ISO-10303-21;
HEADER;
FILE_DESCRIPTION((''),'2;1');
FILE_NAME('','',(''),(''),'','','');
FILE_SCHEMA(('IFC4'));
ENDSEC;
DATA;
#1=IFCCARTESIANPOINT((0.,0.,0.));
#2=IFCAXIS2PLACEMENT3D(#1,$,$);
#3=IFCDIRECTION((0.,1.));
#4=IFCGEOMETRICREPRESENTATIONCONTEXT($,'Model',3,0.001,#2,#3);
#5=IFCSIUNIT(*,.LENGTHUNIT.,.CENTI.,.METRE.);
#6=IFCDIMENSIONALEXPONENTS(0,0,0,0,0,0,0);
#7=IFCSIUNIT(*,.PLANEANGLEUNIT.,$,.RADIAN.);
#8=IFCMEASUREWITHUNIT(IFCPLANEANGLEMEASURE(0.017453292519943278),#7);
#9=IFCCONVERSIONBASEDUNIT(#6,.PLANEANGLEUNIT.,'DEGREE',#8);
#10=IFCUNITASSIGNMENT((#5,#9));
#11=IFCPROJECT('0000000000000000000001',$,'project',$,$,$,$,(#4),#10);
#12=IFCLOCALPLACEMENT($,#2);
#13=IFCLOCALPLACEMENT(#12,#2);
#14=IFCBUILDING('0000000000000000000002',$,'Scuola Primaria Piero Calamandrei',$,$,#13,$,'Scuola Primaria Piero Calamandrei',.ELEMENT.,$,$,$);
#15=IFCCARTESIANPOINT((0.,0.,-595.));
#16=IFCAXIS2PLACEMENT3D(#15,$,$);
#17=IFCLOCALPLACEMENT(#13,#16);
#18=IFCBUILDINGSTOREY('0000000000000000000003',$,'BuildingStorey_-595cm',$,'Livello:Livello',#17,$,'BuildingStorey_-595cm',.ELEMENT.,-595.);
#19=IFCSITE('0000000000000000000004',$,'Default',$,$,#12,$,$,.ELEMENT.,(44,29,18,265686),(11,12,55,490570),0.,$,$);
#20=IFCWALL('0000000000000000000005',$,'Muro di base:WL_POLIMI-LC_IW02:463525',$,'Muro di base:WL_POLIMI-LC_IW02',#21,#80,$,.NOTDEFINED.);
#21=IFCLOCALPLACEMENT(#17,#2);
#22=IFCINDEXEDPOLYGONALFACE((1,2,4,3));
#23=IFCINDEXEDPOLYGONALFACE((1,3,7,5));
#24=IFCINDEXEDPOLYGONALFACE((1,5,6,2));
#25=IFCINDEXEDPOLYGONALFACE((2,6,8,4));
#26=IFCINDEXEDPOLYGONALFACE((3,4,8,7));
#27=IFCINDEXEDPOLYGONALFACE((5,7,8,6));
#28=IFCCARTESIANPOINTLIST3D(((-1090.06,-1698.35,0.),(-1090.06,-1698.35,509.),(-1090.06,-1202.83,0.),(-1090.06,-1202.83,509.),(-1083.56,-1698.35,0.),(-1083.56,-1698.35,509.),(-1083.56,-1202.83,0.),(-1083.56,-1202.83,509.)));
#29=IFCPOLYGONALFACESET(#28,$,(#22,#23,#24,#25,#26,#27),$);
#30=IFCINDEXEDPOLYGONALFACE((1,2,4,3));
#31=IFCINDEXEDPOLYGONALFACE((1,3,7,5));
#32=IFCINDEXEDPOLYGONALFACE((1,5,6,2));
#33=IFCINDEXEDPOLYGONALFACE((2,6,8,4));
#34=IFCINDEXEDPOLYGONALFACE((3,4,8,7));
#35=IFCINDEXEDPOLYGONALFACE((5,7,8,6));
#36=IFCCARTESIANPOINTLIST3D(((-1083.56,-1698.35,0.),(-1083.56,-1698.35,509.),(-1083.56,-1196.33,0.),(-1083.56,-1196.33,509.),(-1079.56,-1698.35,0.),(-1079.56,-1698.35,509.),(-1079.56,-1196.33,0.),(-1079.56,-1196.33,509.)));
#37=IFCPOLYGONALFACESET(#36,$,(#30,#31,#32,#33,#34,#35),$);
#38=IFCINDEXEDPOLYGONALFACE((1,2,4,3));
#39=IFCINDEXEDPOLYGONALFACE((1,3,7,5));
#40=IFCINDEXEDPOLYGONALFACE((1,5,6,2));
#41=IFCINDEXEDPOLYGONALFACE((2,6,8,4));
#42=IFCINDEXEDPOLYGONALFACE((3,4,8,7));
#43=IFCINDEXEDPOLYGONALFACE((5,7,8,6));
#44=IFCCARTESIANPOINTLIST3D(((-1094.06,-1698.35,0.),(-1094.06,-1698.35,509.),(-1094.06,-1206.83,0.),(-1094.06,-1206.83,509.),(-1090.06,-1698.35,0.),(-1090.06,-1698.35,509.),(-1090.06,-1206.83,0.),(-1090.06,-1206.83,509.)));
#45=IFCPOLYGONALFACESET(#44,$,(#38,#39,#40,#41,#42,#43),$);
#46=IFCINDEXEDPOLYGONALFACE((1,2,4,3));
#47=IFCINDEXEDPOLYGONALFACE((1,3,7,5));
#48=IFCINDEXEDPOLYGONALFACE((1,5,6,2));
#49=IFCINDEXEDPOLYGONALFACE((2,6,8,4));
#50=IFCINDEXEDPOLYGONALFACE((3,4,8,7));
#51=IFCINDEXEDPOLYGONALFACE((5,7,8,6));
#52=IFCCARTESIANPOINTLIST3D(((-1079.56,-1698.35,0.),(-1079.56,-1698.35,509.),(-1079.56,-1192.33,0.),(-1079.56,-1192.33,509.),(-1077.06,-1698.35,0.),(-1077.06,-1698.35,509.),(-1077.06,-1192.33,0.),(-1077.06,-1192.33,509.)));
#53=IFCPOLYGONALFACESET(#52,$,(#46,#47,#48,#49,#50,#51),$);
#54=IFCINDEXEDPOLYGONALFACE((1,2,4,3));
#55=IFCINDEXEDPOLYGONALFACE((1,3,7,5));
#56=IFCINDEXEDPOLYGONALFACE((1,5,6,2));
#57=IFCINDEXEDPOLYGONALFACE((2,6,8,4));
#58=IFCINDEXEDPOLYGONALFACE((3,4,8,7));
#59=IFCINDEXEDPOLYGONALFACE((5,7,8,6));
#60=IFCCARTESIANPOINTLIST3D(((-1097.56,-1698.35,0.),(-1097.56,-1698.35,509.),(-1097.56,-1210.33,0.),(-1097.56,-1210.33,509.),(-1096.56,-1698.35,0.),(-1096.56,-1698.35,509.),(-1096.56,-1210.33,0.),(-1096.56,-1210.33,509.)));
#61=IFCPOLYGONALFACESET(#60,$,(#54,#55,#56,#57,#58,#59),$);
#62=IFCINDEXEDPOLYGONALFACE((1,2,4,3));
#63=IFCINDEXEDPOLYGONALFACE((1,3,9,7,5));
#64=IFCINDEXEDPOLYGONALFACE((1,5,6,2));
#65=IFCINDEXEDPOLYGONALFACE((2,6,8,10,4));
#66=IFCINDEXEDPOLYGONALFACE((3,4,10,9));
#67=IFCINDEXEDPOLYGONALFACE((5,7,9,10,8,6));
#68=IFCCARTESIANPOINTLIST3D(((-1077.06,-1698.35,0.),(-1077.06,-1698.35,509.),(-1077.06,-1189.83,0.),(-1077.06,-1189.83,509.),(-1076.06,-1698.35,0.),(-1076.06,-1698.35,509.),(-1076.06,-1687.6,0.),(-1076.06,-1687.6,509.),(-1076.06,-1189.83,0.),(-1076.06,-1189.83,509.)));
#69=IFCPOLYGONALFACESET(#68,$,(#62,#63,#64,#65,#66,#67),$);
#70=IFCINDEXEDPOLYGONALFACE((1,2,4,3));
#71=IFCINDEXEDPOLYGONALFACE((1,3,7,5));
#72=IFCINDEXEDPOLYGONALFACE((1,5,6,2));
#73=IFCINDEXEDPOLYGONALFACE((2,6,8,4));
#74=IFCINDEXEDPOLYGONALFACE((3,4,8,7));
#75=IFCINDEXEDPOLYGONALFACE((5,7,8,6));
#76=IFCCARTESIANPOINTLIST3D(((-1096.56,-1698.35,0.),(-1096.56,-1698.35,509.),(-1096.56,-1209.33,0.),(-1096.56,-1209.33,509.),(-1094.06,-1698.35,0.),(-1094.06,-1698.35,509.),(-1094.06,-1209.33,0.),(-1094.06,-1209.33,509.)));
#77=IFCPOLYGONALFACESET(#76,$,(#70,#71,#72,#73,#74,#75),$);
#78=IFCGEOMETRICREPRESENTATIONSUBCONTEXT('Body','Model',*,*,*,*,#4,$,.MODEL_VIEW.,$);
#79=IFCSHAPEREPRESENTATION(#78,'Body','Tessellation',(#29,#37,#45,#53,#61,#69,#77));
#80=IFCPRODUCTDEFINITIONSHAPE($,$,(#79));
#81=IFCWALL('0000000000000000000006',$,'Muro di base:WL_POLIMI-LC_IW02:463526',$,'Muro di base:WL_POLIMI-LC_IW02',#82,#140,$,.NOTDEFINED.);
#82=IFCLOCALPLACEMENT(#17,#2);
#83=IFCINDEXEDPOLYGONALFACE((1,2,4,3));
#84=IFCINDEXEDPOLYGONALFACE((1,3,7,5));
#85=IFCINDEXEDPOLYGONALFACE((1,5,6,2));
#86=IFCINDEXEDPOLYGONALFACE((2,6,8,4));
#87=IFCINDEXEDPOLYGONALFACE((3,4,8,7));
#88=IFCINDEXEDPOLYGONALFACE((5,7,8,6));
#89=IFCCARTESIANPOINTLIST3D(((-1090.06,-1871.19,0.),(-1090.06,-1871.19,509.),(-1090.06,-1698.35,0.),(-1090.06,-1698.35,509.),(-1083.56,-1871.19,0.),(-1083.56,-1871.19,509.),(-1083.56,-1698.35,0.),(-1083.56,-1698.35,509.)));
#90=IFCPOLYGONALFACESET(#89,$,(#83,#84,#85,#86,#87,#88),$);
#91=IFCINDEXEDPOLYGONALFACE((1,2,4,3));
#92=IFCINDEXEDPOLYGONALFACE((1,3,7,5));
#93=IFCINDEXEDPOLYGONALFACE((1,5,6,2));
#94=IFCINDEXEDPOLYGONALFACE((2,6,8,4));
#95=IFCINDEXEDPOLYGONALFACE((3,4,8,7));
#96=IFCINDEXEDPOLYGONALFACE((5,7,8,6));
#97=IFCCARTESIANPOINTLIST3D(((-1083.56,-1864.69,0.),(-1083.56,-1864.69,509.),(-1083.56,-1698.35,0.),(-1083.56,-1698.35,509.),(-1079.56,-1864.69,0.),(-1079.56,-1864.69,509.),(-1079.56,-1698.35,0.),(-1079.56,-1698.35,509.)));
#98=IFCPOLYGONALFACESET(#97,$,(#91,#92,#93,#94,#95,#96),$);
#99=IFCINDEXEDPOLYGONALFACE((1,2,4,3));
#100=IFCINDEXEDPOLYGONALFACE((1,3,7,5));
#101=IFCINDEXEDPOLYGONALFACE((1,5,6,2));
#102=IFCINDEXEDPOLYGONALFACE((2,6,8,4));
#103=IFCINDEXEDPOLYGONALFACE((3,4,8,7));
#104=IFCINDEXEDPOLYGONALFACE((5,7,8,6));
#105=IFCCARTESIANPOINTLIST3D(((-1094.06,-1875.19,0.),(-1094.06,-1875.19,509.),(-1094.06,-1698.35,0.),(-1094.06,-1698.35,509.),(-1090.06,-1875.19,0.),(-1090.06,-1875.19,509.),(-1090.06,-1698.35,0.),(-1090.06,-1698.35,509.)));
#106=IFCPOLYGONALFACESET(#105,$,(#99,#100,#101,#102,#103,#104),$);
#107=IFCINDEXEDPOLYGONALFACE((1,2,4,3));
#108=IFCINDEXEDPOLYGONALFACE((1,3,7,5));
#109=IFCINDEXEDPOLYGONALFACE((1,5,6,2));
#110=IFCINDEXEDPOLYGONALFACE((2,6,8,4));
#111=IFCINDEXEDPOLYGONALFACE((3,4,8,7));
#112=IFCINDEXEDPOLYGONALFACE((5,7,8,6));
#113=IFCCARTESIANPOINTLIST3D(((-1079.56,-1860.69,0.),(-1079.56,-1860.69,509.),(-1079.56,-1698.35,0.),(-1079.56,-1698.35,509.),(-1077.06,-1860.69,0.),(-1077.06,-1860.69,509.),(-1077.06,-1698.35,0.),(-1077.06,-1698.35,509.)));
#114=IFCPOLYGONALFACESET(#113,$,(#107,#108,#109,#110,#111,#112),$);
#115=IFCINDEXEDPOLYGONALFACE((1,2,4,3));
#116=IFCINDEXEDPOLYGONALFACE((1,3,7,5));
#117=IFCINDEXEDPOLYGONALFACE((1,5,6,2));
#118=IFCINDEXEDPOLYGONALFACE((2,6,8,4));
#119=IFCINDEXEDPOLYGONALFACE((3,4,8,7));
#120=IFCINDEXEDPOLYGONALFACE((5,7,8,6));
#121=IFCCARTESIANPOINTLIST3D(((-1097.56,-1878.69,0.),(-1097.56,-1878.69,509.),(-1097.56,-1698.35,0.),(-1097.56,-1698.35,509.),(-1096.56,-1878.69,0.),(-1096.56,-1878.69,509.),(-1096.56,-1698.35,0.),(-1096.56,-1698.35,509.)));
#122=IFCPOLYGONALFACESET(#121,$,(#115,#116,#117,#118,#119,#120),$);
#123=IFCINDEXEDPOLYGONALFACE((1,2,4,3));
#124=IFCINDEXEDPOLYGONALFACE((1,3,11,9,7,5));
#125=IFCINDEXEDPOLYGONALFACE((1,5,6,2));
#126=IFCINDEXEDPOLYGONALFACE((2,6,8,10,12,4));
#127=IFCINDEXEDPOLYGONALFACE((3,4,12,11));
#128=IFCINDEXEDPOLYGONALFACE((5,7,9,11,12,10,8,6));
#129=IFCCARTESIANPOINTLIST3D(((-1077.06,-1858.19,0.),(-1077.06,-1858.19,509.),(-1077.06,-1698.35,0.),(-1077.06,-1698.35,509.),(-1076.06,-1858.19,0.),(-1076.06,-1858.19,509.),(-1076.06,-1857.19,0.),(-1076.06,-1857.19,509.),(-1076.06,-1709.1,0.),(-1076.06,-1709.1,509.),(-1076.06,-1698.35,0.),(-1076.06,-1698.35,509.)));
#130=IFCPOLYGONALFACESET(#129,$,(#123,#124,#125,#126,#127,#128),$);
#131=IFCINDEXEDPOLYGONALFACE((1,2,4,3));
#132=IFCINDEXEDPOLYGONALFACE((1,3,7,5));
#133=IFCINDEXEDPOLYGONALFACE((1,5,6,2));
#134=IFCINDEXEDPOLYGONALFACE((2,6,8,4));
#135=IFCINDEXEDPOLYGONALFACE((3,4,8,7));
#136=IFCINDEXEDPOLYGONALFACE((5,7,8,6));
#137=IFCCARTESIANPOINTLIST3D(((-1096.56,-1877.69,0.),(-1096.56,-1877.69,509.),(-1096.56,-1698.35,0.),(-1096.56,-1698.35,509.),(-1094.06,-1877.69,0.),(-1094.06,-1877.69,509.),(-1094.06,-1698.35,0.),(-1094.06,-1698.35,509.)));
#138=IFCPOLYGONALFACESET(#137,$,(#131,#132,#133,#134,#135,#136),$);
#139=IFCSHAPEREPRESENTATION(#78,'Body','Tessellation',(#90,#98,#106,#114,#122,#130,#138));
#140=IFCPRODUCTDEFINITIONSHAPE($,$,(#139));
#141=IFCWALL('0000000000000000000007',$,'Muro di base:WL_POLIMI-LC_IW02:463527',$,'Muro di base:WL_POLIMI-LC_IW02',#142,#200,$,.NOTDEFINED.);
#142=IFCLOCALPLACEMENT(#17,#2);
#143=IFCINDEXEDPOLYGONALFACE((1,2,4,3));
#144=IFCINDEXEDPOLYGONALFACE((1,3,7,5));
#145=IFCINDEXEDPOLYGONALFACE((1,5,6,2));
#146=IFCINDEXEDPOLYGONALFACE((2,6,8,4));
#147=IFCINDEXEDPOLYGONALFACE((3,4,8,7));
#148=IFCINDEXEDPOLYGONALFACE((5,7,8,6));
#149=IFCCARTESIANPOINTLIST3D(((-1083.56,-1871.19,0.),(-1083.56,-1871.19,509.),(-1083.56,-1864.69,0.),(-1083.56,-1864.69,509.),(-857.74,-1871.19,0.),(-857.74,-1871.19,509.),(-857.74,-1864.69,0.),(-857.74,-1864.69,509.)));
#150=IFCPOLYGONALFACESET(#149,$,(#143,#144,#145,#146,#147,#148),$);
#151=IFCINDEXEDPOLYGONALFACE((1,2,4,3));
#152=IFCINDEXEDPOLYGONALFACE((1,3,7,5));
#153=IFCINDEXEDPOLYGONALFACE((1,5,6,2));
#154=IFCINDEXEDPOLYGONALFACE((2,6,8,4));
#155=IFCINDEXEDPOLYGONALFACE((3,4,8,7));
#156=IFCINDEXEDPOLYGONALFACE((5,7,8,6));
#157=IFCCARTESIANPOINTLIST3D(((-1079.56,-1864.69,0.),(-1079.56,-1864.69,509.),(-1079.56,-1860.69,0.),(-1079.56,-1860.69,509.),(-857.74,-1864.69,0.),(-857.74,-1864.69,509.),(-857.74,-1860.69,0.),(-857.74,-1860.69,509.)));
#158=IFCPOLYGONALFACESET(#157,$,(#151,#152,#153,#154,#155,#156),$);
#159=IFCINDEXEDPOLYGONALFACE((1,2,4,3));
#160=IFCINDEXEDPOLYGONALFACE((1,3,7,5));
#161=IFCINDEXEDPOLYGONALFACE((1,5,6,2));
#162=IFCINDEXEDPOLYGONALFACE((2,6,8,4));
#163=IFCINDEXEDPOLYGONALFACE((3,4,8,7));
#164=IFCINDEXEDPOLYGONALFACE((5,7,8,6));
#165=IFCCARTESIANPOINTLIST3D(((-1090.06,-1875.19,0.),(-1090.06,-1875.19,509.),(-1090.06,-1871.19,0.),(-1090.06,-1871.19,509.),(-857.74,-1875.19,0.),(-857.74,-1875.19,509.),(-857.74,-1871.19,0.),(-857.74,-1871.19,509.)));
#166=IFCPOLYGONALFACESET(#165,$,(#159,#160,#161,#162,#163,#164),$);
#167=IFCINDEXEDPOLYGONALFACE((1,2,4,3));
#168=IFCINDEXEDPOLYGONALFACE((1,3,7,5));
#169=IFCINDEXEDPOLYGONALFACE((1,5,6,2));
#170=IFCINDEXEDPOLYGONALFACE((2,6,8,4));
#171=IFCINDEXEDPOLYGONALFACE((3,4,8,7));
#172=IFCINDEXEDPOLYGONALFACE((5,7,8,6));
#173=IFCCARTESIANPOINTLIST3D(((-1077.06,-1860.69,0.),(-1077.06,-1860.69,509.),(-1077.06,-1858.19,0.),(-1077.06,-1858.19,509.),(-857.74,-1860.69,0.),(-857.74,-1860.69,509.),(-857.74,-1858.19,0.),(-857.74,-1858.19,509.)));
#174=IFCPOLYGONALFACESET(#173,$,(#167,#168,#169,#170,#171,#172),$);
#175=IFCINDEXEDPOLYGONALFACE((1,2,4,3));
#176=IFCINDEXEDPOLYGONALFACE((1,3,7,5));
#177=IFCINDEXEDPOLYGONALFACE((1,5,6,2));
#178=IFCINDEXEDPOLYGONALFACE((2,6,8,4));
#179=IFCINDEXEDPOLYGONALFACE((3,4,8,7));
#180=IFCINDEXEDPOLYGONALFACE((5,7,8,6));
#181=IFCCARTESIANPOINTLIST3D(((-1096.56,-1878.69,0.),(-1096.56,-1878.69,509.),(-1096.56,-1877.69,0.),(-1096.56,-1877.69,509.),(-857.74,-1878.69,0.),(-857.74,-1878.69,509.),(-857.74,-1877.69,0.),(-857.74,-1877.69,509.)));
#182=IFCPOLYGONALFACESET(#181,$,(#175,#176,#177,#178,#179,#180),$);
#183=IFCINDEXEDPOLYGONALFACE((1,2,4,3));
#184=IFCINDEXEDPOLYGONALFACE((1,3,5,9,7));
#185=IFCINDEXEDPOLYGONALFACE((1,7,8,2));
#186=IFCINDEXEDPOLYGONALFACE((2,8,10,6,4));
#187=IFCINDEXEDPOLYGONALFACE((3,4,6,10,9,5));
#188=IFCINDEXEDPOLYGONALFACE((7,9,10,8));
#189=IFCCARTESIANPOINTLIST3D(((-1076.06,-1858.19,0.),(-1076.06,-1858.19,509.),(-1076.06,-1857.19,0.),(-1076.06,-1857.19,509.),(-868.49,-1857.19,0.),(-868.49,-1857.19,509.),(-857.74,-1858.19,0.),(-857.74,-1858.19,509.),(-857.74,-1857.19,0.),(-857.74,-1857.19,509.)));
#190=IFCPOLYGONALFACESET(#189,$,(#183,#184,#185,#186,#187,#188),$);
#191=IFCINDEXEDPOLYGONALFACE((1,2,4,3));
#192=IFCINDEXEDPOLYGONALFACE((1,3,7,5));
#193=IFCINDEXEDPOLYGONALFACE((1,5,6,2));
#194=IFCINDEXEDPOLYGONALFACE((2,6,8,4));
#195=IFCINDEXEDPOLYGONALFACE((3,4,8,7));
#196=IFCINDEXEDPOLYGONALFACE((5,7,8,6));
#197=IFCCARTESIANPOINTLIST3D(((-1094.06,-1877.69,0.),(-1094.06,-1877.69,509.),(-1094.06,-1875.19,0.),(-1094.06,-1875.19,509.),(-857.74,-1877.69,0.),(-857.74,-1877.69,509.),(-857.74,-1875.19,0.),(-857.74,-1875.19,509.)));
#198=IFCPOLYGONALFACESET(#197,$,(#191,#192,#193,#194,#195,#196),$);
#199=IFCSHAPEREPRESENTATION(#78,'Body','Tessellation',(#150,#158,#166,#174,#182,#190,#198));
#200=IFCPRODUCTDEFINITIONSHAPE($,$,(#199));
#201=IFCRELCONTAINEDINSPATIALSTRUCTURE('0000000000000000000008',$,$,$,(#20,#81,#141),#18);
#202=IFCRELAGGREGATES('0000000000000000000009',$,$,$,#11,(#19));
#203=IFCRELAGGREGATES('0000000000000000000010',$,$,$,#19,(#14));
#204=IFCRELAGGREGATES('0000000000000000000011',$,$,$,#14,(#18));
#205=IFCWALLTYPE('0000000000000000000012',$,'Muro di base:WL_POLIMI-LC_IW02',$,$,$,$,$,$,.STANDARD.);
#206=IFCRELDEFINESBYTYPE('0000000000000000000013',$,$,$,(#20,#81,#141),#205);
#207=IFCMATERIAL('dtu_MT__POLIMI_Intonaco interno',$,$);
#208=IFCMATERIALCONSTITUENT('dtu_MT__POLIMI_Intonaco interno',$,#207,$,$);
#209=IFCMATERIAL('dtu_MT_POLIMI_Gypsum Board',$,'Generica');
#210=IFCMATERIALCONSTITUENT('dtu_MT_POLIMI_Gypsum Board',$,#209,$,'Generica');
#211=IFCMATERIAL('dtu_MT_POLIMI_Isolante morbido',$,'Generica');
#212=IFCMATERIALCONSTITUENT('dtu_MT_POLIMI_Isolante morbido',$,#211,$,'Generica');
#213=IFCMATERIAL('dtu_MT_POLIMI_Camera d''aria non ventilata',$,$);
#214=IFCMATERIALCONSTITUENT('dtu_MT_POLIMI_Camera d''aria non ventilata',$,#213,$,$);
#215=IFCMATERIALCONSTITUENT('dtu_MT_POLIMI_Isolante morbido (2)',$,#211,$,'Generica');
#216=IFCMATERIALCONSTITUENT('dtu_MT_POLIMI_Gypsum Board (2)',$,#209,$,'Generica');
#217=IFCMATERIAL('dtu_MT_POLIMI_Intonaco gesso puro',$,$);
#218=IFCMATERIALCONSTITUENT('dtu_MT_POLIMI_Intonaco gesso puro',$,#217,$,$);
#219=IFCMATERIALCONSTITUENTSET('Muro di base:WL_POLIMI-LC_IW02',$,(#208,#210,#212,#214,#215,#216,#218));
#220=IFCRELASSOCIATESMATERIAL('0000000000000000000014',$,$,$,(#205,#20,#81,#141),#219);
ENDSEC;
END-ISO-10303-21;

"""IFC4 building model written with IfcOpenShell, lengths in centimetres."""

from ifc_helpers import new_model, entity, si_unit, converted_unit, direction, frame, origin, place, context, subcontext, project, spatial, indexed_curve, outline, extrude, material, constituent, constituent_set, type_object, element, save


model = new_model("IFC4")

# Units and contexts
model_context = context("Model", 3, precision=0.001, world=origin(), true_north=direction((0.0, 1.0)))
body_context = subcontext(model_context, "Body", "Model", "MODEL_VIEW")
ifc_project = project(units=[si_unit("LENGTHUNIT", "METRE", prefix="CENTI"), converted_unit("PLANEANGLEUNIT", "DEGREE", entity("IfcPlaneAngleMeasure", 0.017453292519943278), si_unit("PLANEANGLEUNIT", "RADIAN"), dimensions=[0, 0, 0, 0, 0, 0, 0])], contexts=[model_context])

# Site, building, storey
site_placement = place(None, origin())
site = spatial("IfcSite", under=ifc_project, at=site_placement, Name="Default", CompositionType="ELEMENT", RefLatitude=(44, 29, 18, 265686), RefLongitude=(11, 12, 55, 490570), RefElevation=0.0)
building_placement = place(site_placement, origin())
building = spatial("IfcBuilding", under=site, at=building_placement, Name="Scuola Primaria Piero Calamandrei", LongName="Scuola Primaria Piero Calamandrei", CompositionType="ELEMENT")
storey_placement = place(building_placement, frame((0.0, 0.0, -595.0)))
storey = spatial("IfcBuildingStorey", under=building, at=storey_placement, Name="BuildingStorey_-595cm", ObjectType="Livello:Livello", LongName="BuildingStorey_-595cm", CompositionType="ELEMENT", Elevation=-595.0)

# Shared definitions
ifc_material_1 = material(Name="dtu_MT__POLIMI_Intonaco interno")

# Walls
ifc_constituent_1 = constituent(ifc_material_1, Name="dtu_MT__POLIMI_Intonaco interno")
ifc_material_2 = material(Name="dtu_MT_POLIMI_Gypsum Board", Category="Generica")
ifc_constituent_2 = constituent(ifc_material_2, Name="dtu_MT_POLIMI_Gypsum Board", Category="Generica")
ifc_material_3 = material(Name="dtu_MT_POLIMI_Isolante morbido", Category="Generica")
ifc_constituent_3 = constituent(ifc_material_3, Name="dtu_MT_POLIMI_Isolante morbido", Category="Generica")
ifc_material_4 = material(Name="dtu_MT_POLIMI_Camera d'aria non ventilata")
ifc_constituent_4 = constituent(ifc_material_4, Name="dtu_MT_POLIMI_Camera d'aria non ventilata")
ifc_constituent_5 = constituent(ifc_material_3, Name="dtu_MT_POLIMI_Isolante morbido (2)", Category="Generica")
ifc_constituent_6 = constituent(ifc_material_2, Name="dtu_MT_POLIMI_Gypsum Board (2)", Category="Generica")
ifc_material_5 = material(Name="dtu_MT_POLIMI_Intonaco gesso puro")
ifc_constituent_7 = constituent(ifc_material_5, Name="dtu_MT_POLIMI_Intonaco gesso puro")
ifc_constituent_set_1 = constituent_set(constituents=[ifc_constituent_1, ifc_constituent_2, ifc_constituent_3, ifc_constituent_4, ifc_constituent_5, ifc_constituent_6, ifc_constituent_7], Name="Muro di base:WL_POLIMI-LC_IW02")
wall_type_1 = type_object("IfcWallType", Name="Muro di base:WL_POLIMI-LC_IW02", PredefinedType="STANDARD", material=ifc_constituent_set_1)
wall_1_placement = place(storey_placement, frame((-1086.81, -1210.33, 0.0), z_axis=(0.0, 0.0, 1.0), x_axis=(0.0, -1.0, 0.0)))
element("IfcWall", 1, at=wall_1_placement, inside=storey, type_object=wall_type_1, material=ifc_constituent_set_1, Name="Muro di base:WL_POLIMI-LC_IW02:463525", ObjectType="Muro di base:WL_POLIMI-LC_IW02", PredefinedType="NOTDEFINED", context=body_context, shape_type="SweptSolid", body=[
    extrude(outline(indexed_curve([(-247.76, -3.25), (247.76, -3.25), (247.76, 3.25), (-247.76, 3.25), (-247.76, -3.25)], self_intersect=False)), frame((240.26, 0.0, 0.0)), (0.0, 0.0, 1.0), 509.0),
    extrude(outline(indexed_curve([(-251.01, -2.0), (251.01, -2.0), (251.01, 2.0), (-251.01, 2.0), (-251.01, -2.0)], self_intersect=False)), frame((237.01, 5.25, 0.0)), (0.0, 0.0, 1.0), 509.0),
    extrude(outline(indexed_curve([(-245.76, -2.0), (245.76, -2.0), (245.76, 2.0), (-245.76, 2.0), (-245.76, -2.0)], self_intersect=False)), frame((242.26, -5.25, 0.0)), (0.0, 0.0, 1.0), 509.0),
    extrude(outline(indexed_curve([(-253.01, -1.25), (253.01, -1.25), (253.01, 1.25), (-253.01, 1.25), (-253.01, -1.25)], self_intersect=False)), frame((235.01, 8.5, 0.0)), (0.0, 0.0, 1.0), 509.0),
    extrude(outline(indexed_curve([(-0.5, -244.01), (0.5, -244.01), (0.5, 244.01), (-0.5, 244.01), (-0.5, -244.01)], self_intersect=False)), frame((244.01, -10.25, 0.0), z_axis=(0.0, 0.0, 1.0), x_axis=(0.0, 1.0, 0.0)), (0.0, 0.0, 1.0), 509.0),
    extrude(outline(indexed_curve([(-194.81, -0.4), (302.97, -0.4), (302.97, 0.6), (-205.56, 0.6), (-205.56, -0.4), (-194.81, -0.4)], self_intersect=False)), frame((282.47, 10.35, 0.0), z_axis=(0.0, 0.0, 1.0), x_axis=(-1.0, 0.0, 0.0)), (0.0, 0.0, 1.0), 509.0),
    extrude(outline(indexed_curve([(-244.51, -1.25), (244.51, -1.25), (244.51, 1.25), (-244.51, 1.25), (-244.51, -1.25)], self_intersect=False)), frame((243.51, -8.5, 0.0)), (0.0, 0.0, 1.0), 509.0),
])
wall_2_placement = place(storey_placement, frame((-1086.81, -1698.35, 0.0), z_axis=(0.0, 0.0, 1.0), x_axis=(0.0, -1.0, 0.0)))
element("IfcWall", 2, at=wall_2_placement, inside=storey, type_object=wall_type_1, material=ifc_constituent_set_1, Name="Muro di base:WL_POLIMI-LC_IW02:463526", ObjectType="Muro di base:WL_POLIMI-LC_IW02", PredefinedType="NOTDEFINED", context=body_context, shape_type="SweptSolid", body=[
    extrude(outline(indexed_curve([(-86.42, -3.25), (86.42, -3.25), (86.42, 3.25), (-86.42, 3.25), (-86.42, -3.25)], self_intersect=False)), frame((86.42, 0.0, 0.0)), (0.0, 0.0, 1.0), 509.0),
    extrude(outline(indexed_curve([(-83.17, -2.0), (83.17, -2.0), (83.17, 2.0), (-83.17, 2.0), (-83.17, -2.0)], self_intersect=False)), frame((83.17, 5.25, 0.0)), (0.0, 0.0, 1.0), 509.0),
    extrude(outline(indexed_curve([(-88.42, -2.0), (88.42, -2.0), (88.42, 2.0), (-88.42, 2.0), (-88.42, -2.0)], self_intersect=False)), frame((88.42, -5.25, 0.0)), (0.0, 0.0, 1.0), 509.0),
    extrude(outline(indexed_curve([(-81.17, -1.25), (81.17, -1.25), (81.17, 1.25), (-81.17, 1.25), (-81.17, -1.25)], self_intersect=False)), frame((81.17, 8.5, 0.0)), (0.0, 0.0, 1.0), 509.0),
    extrude(outline(indexed_curve([(-0.5, -90.17), (0.5, -90.17), (0.5, 90.17), (-0.5, 90.17), (-0.5, -90.17)], self_intersect=False)), frame((90.17, -10.25, 0.0), z_axis=(0.0, 0.0, 1.0), x_axis=(0.0, 1.0, 0.0)), (0.0, 0.0, 1.0), 509.0),
    extrude(outline(indexed_curve([(-77.29, -0.33), (70.79, -0.33), (81.54, -0.33), (81.54, 0.67), (-78.29, 0.67), (-78.29, -0.33), (-77.29, -0.33)], self_intersect=False)), frame((81.54, 10.42, 0.0), z_axis=(0.0, 0.0, 1.0), x_axis=(-1.0, 0.0, 0.0)), (0.0, 0.0, 1.0), 509.0),
    extrude(outline(indexed_curve([(-89.67, -1.25), (89.67, -1.25), (89.67, 1.25), (-89.67, 1.25), (-89.67, -1.25)], self_intersect=False)), frame((89.67, -8.5, 0.0)), (0.0, 0.0, 1.0), 509.0),
])
wall_3_placement = place(storey_placement, frame((-1076.06, -1867.94, 0.0)))
element("IfcWall", 3, at=wall_3_placement, inside=storey, type_object=wall_type_1, material=ifc_constituent_set_1, Name="Muro di base:WL_POLIMI-LC_IW02:463527", ObjectType="Muro di base:WL_POLIMI-LC_IW02", PredefinedType="NOTDEFINED", context=body_context, shape_type="SweptSolid", body=[
    extrude(outline(indexed_curve([(-112.91, -3.25), (112.91, -3.25), (112.91, 3.25), (-112.91, 3.25), (-112.91, -3.25)], self_intersect=False)), frame((105.41, 0.0, 0.0)), (0.0, 0.0, 1.0), 509.0),
    extrude(outline(indexed_curve([(-110.91, -2.0), (110.91, -2.0), (110.91, 2.0), (-110.91, 2.0), (-110.91, -2.0)], self_intersect=False)), frame((107.41, 5.25, 0.0)), (0.0, 0.0, 1.0), 509.0),
    extrude(outline(indexed_curve([(-116.16, -2.0), (116.16, -2.0), (116.16, 2.0), (-116.16, 2.0), (-116.16, -2.0)], self_intersect=False)), frame((102.16, -5.25, 0.0)), (0.0, 0.0, 1.0), 509.0),
    extrude(outline(indexed_curve([(-109.66, -1.25), (109.66, -1.25), (109.66, 1.25), (-109.66, 1.25), (-109.66, -1.25)], self_intersect=False)), frame((108.66, 8.5, 0.0)), (0.0, 0.0, 1.0), 509.0),
    extrude(outline(indexed_curve([(-0.5, -119.41), (0.5, -119.41), (0.5, 119.41), (-0.5, 119.41), (-0.5, -119.41)], self_intersect=False)), frame((98.91, -10.25, 0.0), z_axis=(0.0, 0.0, 1.0), x_axis=(0.0, 1.0, 0.0)), (0.0, 0.0, 1.0), 509.0),
    extrude(outline(indexed_curve([(-78.73, -0.4), (128.84, -0.4), (128.84, 0.6), (-89.48, 0.6), (-89.48, -0.4), (-78.73, -0.4)], self_intersect=False)), frame((128.84, 10.35, 0.0), z_axis=(0.0, 0.0, 1.0), x_axis=(-1.0, 0.0, 0.0)), (0.0, 0.0, 1.0), 509.0),
    extrude(outline(indexed_curve([(-118.16, -1.25), (118.16, -1.25), (118.16, 1.25), (-118.16, 1.25), (-118.16, -1.25)], self_intersect=False)), frame((100.16, -8.5, 0.0)), (0.0, 0.0, 1.0), 509.0),
])

save(model, "model.ifc")
